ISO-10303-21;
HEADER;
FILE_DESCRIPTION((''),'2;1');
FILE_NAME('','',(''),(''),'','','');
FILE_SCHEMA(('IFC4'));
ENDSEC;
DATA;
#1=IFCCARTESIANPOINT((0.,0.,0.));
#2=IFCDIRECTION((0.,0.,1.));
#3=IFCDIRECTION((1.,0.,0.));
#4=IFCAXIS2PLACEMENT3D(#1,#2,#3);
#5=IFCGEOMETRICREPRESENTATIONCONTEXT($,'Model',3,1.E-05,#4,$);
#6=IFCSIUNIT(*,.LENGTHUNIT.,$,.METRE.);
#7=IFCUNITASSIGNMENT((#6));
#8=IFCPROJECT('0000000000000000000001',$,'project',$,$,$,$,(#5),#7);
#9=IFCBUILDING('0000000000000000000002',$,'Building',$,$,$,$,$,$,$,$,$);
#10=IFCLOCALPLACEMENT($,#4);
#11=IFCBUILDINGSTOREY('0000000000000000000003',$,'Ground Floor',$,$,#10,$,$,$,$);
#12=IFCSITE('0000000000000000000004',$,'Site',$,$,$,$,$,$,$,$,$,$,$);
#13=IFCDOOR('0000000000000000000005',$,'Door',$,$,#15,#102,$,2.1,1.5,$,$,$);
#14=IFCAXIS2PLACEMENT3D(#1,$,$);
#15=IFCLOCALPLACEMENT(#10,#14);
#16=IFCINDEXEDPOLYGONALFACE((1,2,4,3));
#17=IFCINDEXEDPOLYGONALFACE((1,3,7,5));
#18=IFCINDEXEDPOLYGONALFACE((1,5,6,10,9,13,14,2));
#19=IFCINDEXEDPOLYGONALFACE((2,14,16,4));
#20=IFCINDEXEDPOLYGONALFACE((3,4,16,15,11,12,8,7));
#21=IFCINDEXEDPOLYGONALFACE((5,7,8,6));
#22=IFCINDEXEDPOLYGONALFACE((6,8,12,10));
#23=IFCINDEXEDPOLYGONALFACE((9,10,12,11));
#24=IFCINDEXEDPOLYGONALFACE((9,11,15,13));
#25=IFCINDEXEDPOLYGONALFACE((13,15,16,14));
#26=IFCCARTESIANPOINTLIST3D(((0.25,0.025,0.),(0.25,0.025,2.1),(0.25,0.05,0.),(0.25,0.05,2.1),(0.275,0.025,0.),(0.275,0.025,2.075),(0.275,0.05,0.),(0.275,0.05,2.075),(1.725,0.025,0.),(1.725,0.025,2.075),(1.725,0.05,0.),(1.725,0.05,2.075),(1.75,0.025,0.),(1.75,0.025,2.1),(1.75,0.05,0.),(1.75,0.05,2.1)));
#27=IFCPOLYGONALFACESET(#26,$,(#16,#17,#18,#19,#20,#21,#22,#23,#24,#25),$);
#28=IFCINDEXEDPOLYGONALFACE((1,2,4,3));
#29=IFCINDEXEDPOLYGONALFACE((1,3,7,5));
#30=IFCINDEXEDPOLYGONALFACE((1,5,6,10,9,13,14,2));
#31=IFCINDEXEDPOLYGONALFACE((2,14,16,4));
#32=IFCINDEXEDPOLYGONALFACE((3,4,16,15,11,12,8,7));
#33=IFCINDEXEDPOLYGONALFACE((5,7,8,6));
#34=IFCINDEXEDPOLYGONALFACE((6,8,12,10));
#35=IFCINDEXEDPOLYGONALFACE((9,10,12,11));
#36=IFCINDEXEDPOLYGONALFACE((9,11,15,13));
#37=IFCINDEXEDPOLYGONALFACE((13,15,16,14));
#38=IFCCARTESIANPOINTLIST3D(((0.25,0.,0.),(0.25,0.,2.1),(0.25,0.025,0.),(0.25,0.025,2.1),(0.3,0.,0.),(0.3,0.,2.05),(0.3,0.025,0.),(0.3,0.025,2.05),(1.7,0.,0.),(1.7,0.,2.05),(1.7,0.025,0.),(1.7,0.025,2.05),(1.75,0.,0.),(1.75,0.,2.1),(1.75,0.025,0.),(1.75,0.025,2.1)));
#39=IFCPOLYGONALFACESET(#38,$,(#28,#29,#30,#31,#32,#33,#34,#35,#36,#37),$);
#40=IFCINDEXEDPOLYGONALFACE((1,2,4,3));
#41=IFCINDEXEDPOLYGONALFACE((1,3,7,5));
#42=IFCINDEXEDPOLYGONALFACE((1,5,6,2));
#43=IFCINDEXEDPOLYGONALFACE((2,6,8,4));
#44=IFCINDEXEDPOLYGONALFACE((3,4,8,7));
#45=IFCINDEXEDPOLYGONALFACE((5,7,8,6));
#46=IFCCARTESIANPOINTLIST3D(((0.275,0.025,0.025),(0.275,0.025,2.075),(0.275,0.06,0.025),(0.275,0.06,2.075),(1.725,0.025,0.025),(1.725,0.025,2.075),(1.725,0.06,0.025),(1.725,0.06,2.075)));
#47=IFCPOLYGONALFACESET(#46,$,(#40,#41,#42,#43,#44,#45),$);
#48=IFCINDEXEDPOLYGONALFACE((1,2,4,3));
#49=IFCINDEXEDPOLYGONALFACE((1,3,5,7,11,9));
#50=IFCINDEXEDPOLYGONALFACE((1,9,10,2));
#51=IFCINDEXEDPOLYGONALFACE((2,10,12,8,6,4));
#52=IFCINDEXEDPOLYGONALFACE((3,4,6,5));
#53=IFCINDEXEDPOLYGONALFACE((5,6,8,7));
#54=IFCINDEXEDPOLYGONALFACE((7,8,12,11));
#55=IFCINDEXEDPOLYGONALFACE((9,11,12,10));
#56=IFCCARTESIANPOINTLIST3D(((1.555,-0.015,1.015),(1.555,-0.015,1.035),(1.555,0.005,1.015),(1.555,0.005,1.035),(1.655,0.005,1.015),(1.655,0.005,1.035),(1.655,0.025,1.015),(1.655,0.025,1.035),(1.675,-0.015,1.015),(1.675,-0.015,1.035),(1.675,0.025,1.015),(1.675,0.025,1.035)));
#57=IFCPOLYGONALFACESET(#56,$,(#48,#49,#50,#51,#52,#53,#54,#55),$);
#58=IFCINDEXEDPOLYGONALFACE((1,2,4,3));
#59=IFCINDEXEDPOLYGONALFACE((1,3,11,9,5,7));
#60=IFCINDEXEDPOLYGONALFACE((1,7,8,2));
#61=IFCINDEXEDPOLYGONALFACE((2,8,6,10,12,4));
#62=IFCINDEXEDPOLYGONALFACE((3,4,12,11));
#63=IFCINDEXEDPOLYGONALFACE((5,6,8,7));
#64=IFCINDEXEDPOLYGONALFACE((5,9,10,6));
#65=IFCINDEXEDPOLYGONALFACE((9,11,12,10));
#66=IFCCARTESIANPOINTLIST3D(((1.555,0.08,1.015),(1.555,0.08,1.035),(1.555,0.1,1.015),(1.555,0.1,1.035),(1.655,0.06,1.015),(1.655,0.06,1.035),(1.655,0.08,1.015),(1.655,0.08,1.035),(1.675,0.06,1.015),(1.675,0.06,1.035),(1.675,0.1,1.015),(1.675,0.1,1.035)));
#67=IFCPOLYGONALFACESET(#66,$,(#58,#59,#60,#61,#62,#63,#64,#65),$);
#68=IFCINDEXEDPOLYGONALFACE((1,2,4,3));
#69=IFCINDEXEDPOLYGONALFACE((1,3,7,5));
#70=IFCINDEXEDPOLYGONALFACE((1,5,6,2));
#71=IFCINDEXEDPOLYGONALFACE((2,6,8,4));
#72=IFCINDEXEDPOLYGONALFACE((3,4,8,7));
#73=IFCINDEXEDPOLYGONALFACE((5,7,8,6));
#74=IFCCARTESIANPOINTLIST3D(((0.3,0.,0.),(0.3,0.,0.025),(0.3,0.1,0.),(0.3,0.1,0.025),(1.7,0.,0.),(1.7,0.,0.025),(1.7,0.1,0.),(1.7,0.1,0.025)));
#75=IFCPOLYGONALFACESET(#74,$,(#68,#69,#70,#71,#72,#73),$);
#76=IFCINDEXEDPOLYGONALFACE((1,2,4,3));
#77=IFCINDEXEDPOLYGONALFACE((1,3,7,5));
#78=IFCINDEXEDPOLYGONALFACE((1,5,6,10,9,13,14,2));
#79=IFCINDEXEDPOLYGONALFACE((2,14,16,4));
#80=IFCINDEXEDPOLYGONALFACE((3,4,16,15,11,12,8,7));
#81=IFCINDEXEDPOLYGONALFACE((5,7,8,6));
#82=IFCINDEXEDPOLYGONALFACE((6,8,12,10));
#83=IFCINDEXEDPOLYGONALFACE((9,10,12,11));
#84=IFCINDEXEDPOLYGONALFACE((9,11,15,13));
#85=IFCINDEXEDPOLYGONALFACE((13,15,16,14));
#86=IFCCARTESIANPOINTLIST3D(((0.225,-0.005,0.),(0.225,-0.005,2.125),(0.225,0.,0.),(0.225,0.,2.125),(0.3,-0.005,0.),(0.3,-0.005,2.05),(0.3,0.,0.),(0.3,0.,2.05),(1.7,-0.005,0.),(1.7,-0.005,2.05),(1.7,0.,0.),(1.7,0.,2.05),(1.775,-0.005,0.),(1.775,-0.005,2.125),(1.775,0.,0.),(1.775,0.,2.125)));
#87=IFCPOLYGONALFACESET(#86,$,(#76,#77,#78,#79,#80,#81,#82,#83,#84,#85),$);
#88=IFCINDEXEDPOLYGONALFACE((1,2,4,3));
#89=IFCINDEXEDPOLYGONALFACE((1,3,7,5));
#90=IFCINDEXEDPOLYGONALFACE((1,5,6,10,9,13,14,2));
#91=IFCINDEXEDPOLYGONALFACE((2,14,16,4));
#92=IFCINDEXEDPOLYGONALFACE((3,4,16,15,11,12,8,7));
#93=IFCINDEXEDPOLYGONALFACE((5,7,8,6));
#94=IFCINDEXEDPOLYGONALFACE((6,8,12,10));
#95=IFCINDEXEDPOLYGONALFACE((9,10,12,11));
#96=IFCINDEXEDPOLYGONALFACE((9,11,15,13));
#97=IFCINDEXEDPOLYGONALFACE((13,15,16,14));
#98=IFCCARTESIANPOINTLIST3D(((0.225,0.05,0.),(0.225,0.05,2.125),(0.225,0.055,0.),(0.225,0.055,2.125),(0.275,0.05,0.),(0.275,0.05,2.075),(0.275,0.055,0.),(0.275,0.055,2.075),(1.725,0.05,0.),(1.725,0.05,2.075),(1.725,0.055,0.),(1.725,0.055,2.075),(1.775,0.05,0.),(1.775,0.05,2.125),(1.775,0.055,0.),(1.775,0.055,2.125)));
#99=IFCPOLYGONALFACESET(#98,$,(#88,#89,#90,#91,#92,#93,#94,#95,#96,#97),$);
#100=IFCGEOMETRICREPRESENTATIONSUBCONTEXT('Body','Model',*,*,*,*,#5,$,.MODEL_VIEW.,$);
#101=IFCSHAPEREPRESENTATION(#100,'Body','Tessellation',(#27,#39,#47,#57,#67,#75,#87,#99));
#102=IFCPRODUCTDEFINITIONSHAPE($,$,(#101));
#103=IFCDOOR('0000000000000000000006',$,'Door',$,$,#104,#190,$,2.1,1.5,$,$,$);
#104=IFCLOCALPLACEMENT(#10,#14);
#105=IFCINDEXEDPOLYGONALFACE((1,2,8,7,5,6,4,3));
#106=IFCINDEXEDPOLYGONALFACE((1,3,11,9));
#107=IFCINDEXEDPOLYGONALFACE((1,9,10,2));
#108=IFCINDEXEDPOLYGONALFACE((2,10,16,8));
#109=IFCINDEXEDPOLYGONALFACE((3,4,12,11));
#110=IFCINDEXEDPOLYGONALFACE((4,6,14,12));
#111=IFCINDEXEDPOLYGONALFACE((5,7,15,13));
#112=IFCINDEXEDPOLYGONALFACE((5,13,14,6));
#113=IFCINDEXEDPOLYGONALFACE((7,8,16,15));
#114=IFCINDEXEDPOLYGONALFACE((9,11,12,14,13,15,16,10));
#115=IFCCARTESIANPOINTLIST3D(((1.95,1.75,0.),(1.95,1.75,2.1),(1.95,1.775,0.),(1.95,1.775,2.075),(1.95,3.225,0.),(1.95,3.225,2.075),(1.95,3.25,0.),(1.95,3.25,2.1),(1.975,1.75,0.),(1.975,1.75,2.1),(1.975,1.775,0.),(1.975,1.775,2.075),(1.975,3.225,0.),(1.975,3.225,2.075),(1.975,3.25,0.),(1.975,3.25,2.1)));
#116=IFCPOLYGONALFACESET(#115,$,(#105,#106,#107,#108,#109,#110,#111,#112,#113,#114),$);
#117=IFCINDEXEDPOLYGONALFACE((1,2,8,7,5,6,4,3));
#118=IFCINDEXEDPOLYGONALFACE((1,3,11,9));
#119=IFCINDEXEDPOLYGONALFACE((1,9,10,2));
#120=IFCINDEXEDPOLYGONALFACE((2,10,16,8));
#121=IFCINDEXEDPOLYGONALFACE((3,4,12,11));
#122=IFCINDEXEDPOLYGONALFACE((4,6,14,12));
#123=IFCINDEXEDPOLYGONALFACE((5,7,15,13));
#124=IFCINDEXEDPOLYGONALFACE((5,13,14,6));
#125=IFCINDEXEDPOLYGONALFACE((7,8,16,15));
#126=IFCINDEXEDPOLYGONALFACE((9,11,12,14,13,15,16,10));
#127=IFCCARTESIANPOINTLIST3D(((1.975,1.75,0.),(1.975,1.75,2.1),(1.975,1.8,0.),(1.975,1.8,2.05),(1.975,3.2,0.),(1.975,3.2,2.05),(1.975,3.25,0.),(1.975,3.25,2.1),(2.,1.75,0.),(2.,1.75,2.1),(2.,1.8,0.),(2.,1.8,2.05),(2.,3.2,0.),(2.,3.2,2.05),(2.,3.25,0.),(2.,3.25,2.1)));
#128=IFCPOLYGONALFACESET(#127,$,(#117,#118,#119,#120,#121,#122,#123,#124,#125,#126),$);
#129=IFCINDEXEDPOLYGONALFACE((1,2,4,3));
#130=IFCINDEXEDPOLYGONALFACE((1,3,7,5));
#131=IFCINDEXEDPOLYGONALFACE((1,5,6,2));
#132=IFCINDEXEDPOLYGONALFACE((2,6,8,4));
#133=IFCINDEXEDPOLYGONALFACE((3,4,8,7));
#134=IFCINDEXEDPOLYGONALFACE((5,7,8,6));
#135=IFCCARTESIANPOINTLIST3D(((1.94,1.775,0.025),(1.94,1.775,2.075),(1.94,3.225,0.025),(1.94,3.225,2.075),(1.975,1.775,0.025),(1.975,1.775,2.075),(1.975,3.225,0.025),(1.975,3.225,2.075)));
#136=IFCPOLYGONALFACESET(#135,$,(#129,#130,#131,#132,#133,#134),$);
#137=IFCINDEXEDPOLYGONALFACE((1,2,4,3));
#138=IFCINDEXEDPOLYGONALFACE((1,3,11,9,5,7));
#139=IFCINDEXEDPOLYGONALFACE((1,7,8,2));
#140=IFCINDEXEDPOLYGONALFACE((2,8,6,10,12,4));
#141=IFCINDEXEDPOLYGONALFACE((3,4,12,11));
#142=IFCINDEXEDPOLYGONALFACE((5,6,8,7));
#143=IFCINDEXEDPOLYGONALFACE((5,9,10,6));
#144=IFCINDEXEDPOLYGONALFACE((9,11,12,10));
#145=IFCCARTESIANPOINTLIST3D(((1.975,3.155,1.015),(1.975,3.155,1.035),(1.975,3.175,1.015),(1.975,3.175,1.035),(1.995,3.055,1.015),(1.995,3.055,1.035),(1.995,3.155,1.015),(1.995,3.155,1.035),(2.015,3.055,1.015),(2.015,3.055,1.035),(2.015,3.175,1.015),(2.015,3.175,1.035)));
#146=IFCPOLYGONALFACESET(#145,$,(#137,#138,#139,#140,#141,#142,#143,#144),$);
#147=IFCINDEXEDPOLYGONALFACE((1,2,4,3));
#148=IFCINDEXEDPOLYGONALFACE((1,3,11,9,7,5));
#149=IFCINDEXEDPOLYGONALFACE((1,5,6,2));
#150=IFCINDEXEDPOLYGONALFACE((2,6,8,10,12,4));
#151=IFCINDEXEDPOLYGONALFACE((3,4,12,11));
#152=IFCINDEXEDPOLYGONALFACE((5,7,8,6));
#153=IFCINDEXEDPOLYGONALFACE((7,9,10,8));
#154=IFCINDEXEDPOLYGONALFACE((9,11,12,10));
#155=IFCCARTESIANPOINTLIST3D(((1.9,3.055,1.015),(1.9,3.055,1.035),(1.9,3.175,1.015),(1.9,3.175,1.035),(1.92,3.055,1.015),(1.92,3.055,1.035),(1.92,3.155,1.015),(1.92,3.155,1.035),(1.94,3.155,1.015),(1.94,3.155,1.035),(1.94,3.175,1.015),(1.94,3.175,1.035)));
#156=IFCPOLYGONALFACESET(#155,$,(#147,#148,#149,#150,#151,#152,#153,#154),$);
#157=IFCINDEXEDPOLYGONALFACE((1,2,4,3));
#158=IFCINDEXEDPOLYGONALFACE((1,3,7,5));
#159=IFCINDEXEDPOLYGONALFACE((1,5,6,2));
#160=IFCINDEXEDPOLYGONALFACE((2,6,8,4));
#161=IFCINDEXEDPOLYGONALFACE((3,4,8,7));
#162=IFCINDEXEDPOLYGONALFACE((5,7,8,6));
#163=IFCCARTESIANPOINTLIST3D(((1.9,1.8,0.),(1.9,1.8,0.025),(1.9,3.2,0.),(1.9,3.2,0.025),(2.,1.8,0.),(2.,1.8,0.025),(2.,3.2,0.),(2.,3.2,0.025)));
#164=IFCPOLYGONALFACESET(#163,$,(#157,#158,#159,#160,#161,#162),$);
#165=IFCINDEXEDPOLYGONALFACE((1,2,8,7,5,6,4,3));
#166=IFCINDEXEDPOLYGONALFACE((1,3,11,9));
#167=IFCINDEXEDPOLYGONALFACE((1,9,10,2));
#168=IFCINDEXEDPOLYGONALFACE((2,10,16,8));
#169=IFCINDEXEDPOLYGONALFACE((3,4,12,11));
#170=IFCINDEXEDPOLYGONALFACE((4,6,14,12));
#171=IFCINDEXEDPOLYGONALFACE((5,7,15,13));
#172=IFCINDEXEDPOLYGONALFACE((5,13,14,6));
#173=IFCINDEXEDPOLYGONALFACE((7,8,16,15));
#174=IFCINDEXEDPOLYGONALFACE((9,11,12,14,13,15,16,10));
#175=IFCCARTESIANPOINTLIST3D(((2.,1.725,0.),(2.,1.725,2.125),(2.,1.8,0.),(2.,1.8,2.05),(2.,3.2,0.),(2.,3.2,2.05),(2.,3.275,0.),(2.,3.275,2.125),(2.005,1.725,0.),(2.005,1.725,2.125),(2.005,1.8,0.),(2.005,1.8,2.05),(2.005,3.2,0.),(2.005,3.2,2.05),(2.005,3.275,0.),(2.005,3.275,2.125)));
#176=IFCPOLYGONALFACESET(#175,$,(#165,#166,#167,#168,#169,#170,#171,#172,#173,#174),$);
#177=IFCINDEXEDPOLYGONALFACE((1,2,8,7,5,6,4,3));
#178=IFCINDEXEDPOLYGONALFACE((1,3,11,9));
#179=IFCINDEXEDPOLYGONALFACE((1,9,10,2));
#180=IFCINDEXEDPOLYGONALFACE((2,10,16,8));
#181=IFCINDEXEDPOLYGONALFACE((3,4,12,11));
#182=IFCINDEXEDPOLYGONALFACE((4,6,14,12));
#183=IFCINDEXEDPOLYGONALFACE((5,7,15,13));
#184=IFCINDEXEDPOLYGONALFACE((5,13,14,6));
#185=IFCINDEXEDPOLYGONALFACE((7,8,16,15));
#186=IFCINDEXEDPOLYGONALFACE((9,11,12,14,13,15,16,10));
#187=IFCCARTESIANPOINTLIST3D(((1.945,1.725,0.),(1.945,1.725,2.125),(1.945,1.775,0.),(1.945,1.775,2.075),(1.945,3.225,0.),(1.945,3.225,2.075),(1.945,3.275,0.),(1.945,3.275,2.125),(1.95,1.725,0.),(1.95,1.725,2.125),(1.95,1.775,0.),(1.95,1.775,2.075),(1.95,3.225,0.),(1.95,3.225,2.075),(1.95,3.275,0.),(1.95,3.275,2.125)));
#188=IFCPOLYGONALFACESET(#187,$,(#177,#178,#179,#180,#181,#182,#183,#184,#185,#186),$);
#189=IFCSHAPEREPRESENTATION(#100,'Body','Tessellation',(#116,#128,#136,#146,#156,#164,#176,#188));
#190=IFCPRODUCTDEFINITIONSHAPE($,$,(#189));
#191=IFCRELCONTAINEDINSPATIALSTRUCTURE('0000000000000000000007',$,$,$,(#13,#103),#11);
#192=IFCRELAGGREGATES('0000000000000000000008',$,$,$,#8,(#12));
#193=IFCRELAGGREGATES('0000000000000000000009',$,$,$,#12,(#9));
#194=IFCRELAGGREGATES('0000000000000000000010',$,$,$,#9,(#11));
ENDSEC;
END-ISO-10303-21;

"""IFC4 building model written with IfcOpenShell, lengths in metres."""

from ifc_helpers import new_model, si_unit, frame, origin_with_axes, place, context, subcontext, project, spatial, line, indexed_curve, outline, extrude, element, save


model = new_model("IFC4")

# Units and contexts
model_context = context("Model", 3, precision=1e-05, world=origin_with_axes())
body_context = subcontext(model_context, "Body", "Model", "MODEL_VIEW")
ifc_project = project(units=[si_unit("LENGTHUNIT", "METRE")], contexts=[model_context])

# Site, building, storey
site = spatial("IfcSite", under=ifc_project, Name="Site")
building = spatial("IfcBuilding", under=site, Name="Building")
storey_placement = place(None, origin_with_axes())
storey = spatial("IfcBuildingStorey", under=building, at=storey_placement, Name="Ground Floor")

# Doors
door_1_placement = place(storey_placement, frame((0.25, 0.0, 0.0), z_axis=(0.0, 0.0, 1.0), x_axis=(1.0, 0.0, 0.0)))
element("IfcDoor", 1, at=door_1_placement, inside=storey, Name="Door", OverallHeight=2.1, OverallWidth=1.5, context=body_context, shape_type="SweptSolid", body=[
    extrude(outline(indexed_curve([(0.0, 0.0), (0.0, 2.1), (1.5, 2.1), (1.5, 0.0), (1.475, 0.0), (1.475, 2.075), (0.025, 2.075), (0.025, 0.0)], segments=[line(1, 2, 3, 4, 5, 6, 7, 8, 1)])), frame((0.0, 0.025, 0.0), z_axis=(0.0, -1.0, 0.0), x_axis=(1.0, 0.0, 0.0)), (0.0, 0.0, -1.0), 0.025),
    extrude(outline(indexed_curve([(0.0, 0.0), (0.0, 2.1), (1.5, 2.1), (1.5, 0.0), (1.45, 0.0), (1.45, 2.05), (0.05, 2.05), (0.05, 0.0)], segments=[line(1, 2, 3, 4, 5, 6, 7, 8, 1)])), frame((0.0, 0.0, 0.0), z_axis=(0.0, -1.0, 0.0), x_axis=(1.0, 0.0, 0.0)), (0.0, 0.0, -1.0), 0.025),
    extrude(outline(indexed_curve([(0.0, 0.0), (1.45, 0.0), (1.45, 0.035), (0.0, 0.035)], segments=[line(1, 2, 3, 4, 1)])), frame((0.025, 0.025, 0.025), z_axis=(0.0, 0.0, 1.0), x_axis=(1.0, 0.0, 0.0)), (0.0, 0.0, 1.0), 2.05),
    extrude(outline(indexed_curve([(0.0, 0.0), (0.0, -0.04), (-0.12, -0.04), (-0.12, -0.02), (-0.02, -0.02), (-0.02, 0.0)], segments=[line(1, 2, 3, 4, 5, 6, 1)])), frame((1.425, 0.025, 1.015), z_axis=(0.0, 0.0, 1.0), x_axis=(1.0, 0.0, 0.0)), (0.0, 0.0, 1.0), 0.02),
    extrude(outline(indexed_curve([(0.0, 0.0), (0.0, 0.04), (-0.12, 0.04), (-0.12, 0.02), (-0.02, 0.02), (-0.02, 0.0)], segments=[line(1, 2, 3, 4, 5, 6, 1)])), frame((1.425, 0.06, 1.015), z_axis=(0.0, 0.0, 1.0), x_axis=(1.0, 0.0, 0.0)), (0.0, 0.0, 1.0), 0.02),
    extrude(outline(indexed_curve([(0.0, 0.0), (1.4, 0.0), (1.4, 0.1), (0.0, 0.1)], segments=[line(1, 2, 3, 4, 1)])), frame((0.05, 0.0, 0.0), z_axis=(0.0, 0.0, 1.0), x_axis=(1.0, 0.0, 0.0)), (0.0, 0.0, 1.0), 0.025),
    extrude(outline(indexed_curve([(0.0, 0.0), (0.0, 2.125), (1.55, 2.125), (1.55, 0.0), (1.475, 0.0), (1.475, 2.05), (0.075, 2.05), (0.075, 0.0)], segments=[line(1, 2, 3, 4, 5, 6, 7, 8, 1)])), frame((-0.025, -0.005, 0.0), z_axis=(0.0, -1.0, 0.0), x_axis=(1.0, 0.0, 0.0)), (0.0, 0.0, -1.0), 0.005),
    extrude(outline(indexed_curve([(0.0, 0.0), (0.0, 2.125), (1.55, 2.125), (1.55, 0.0), (1.5, 0.0), (1.5, 2.075), (0.05, 2.075), (0.05, 0.0)], segments=[line(1, 2, 3, 4, 5, 6, 7, 8, 1)])), frame((-0.025, 0.05, 0.0), z_axis=(0.0, -1.0, 0.0), x_axis=(1.0, 0.0, 0.0)), (0.0, 0.0, -1.0), 0.005),
])
door_2_placement = place(storey_placement, frame((2.0, 1.75, 0.0), z_axis=(0.0, 0.0, 1.0), x_axis=(0.0, 1.0, 0.0)))
element("IfcDoor", 2, at=door_2_placement, inside=storey, Name="Door", OverallHeight=2.1, OverallWidth=1.5, context=body_context, shape_type="SweptSolid", body=[
    extrude(outline(indexed_curve([(0.0, 0.0), (0.0, 2.1), (1.5, 2.1), (1.5, 0.0), (1.475, 0.0), (1.475, 2.075), (0.025, 2.075), (0.025, 0.0)], segments=[line(1, 2, 3, 4, 5, 6, 7, 8, 1)])), frame((0.0, 0.025, 0.0), z_axis=(0.0, -1.0, 0.0), x_axis=(1.0, 0.0, 0.0)), (0.0, 0.0, -1.0), 0.025),
    extrude(outline(indexed_curve([(0.0, 0.0), (0.0, 2.1), (1.5, 2.1), (1.5, 0.0), (1.45, 0.0), (1.45, 2.05), (0.05, 2.05), (0.05, 0.0)], segments=[line(1, 2, 3, 4, 5, 6, 7, 8, 1)])), frame((0.0, 0.0, 0.0), z_axis=(0.0, -1.0, 0.0), x_axis=(1.0, 0.0, 0.0)), (0.0, 0.0, -1.0), 0.025),
    extrude(outline(indexed_curve([(0.0, 0.0), (1.45, 0.0), (1.45, 0.035), (0.0, 0.035)], segments=[line(1, 2, 3, 4, 1)])), frame((0.025, 0.025, 0.025), z_axis=(0.0, 0.0, 1.0), x_axis=(1.0, 0.0, 0.0)), (0.0, 0.0, 1.0), 2.05),
    extrude(outline(indexed_curve([(0.0, 0.0), (0.0, -0.04), (-0.12, -0.04), (-0.12, -0.02), (-0.02, -0.02), (-0.02, 0.0)], segments=[line(1, 2, 3, 4, 5, 6, 1)])), frame((1.425, 0.025, 1.015), z_axis=(0.0, 0.0, 1.0), x_axis=(1.0, 0.0, 0.0)), (0.0, 0.0, 1.0), 0.02),
    extrude(outline(indexed_curve([(0.0, 0.0), (0.0, 0.04), (-0.12, 0.04), (-0.12, 0.02), (-0.02, 0.02), (-0.02, 0.0)], segments=[line(1, 2, 3, 4, 5, 6, 1)])), frame((1.425, 0.06, 1.015), z_axis=(0.0, 0.0, 1.0), x_axis=(1.0, 0.0, 0.0)), (0.0, 0.0, 1.0), 0.02),
    extrude(outline(indexed_curve([(0.0, 0.0), (1.4, 0.0), (1.4, 0.1), (0.0, 0.1)], segments=[line(1, 2, 3, 4, 1)])), frame((0.05, 0.0, 0.0), z_axis=(0.0, 0.0, 1.0), x_axis=(1.0, 0.0, 0.0)), (0.0, 0.0, 1.0), 0.025),
    extrude(outline(indexed_curve([(0.0, 0.0), (0.0, 2.125), (1.55, 2.125), (1.55, 0.0), (1.475, 0.0), (1.475, 2.05), (0.075, 2.05), (0.075, 0.0)], segments=[line(1, 2, 3, 4, 5, 6, 7, 8, 1)])), frame((-0.025, -0.005, 0.0), z_axis=(0.0, -1.0, 0.0), x_axis=(1.0, 0.0, 0.0)), (0.0, 0.0, -1.0), 0.005),
    extrude(outline(indexed_curve([(0.0, 0.0), (0.0, 2.125), (1.55, 2.125), (1.55, 0.0), (1.5, 0.0), (1.5, 2.075), (0.05, 2.075), (0.05, 0.0)], segments=[line(1, 2, 3, 4, 5, 6, 7, 8, 1)])), frame((-0.025, 0.05, 0.0), z_axis=(0.0, -1.0, 0.0), x_axis=(1.0, 0.0, 0.0)), (0.0, 0.0, -1.0), 0.005),
])

save(model, "model.ifc")
